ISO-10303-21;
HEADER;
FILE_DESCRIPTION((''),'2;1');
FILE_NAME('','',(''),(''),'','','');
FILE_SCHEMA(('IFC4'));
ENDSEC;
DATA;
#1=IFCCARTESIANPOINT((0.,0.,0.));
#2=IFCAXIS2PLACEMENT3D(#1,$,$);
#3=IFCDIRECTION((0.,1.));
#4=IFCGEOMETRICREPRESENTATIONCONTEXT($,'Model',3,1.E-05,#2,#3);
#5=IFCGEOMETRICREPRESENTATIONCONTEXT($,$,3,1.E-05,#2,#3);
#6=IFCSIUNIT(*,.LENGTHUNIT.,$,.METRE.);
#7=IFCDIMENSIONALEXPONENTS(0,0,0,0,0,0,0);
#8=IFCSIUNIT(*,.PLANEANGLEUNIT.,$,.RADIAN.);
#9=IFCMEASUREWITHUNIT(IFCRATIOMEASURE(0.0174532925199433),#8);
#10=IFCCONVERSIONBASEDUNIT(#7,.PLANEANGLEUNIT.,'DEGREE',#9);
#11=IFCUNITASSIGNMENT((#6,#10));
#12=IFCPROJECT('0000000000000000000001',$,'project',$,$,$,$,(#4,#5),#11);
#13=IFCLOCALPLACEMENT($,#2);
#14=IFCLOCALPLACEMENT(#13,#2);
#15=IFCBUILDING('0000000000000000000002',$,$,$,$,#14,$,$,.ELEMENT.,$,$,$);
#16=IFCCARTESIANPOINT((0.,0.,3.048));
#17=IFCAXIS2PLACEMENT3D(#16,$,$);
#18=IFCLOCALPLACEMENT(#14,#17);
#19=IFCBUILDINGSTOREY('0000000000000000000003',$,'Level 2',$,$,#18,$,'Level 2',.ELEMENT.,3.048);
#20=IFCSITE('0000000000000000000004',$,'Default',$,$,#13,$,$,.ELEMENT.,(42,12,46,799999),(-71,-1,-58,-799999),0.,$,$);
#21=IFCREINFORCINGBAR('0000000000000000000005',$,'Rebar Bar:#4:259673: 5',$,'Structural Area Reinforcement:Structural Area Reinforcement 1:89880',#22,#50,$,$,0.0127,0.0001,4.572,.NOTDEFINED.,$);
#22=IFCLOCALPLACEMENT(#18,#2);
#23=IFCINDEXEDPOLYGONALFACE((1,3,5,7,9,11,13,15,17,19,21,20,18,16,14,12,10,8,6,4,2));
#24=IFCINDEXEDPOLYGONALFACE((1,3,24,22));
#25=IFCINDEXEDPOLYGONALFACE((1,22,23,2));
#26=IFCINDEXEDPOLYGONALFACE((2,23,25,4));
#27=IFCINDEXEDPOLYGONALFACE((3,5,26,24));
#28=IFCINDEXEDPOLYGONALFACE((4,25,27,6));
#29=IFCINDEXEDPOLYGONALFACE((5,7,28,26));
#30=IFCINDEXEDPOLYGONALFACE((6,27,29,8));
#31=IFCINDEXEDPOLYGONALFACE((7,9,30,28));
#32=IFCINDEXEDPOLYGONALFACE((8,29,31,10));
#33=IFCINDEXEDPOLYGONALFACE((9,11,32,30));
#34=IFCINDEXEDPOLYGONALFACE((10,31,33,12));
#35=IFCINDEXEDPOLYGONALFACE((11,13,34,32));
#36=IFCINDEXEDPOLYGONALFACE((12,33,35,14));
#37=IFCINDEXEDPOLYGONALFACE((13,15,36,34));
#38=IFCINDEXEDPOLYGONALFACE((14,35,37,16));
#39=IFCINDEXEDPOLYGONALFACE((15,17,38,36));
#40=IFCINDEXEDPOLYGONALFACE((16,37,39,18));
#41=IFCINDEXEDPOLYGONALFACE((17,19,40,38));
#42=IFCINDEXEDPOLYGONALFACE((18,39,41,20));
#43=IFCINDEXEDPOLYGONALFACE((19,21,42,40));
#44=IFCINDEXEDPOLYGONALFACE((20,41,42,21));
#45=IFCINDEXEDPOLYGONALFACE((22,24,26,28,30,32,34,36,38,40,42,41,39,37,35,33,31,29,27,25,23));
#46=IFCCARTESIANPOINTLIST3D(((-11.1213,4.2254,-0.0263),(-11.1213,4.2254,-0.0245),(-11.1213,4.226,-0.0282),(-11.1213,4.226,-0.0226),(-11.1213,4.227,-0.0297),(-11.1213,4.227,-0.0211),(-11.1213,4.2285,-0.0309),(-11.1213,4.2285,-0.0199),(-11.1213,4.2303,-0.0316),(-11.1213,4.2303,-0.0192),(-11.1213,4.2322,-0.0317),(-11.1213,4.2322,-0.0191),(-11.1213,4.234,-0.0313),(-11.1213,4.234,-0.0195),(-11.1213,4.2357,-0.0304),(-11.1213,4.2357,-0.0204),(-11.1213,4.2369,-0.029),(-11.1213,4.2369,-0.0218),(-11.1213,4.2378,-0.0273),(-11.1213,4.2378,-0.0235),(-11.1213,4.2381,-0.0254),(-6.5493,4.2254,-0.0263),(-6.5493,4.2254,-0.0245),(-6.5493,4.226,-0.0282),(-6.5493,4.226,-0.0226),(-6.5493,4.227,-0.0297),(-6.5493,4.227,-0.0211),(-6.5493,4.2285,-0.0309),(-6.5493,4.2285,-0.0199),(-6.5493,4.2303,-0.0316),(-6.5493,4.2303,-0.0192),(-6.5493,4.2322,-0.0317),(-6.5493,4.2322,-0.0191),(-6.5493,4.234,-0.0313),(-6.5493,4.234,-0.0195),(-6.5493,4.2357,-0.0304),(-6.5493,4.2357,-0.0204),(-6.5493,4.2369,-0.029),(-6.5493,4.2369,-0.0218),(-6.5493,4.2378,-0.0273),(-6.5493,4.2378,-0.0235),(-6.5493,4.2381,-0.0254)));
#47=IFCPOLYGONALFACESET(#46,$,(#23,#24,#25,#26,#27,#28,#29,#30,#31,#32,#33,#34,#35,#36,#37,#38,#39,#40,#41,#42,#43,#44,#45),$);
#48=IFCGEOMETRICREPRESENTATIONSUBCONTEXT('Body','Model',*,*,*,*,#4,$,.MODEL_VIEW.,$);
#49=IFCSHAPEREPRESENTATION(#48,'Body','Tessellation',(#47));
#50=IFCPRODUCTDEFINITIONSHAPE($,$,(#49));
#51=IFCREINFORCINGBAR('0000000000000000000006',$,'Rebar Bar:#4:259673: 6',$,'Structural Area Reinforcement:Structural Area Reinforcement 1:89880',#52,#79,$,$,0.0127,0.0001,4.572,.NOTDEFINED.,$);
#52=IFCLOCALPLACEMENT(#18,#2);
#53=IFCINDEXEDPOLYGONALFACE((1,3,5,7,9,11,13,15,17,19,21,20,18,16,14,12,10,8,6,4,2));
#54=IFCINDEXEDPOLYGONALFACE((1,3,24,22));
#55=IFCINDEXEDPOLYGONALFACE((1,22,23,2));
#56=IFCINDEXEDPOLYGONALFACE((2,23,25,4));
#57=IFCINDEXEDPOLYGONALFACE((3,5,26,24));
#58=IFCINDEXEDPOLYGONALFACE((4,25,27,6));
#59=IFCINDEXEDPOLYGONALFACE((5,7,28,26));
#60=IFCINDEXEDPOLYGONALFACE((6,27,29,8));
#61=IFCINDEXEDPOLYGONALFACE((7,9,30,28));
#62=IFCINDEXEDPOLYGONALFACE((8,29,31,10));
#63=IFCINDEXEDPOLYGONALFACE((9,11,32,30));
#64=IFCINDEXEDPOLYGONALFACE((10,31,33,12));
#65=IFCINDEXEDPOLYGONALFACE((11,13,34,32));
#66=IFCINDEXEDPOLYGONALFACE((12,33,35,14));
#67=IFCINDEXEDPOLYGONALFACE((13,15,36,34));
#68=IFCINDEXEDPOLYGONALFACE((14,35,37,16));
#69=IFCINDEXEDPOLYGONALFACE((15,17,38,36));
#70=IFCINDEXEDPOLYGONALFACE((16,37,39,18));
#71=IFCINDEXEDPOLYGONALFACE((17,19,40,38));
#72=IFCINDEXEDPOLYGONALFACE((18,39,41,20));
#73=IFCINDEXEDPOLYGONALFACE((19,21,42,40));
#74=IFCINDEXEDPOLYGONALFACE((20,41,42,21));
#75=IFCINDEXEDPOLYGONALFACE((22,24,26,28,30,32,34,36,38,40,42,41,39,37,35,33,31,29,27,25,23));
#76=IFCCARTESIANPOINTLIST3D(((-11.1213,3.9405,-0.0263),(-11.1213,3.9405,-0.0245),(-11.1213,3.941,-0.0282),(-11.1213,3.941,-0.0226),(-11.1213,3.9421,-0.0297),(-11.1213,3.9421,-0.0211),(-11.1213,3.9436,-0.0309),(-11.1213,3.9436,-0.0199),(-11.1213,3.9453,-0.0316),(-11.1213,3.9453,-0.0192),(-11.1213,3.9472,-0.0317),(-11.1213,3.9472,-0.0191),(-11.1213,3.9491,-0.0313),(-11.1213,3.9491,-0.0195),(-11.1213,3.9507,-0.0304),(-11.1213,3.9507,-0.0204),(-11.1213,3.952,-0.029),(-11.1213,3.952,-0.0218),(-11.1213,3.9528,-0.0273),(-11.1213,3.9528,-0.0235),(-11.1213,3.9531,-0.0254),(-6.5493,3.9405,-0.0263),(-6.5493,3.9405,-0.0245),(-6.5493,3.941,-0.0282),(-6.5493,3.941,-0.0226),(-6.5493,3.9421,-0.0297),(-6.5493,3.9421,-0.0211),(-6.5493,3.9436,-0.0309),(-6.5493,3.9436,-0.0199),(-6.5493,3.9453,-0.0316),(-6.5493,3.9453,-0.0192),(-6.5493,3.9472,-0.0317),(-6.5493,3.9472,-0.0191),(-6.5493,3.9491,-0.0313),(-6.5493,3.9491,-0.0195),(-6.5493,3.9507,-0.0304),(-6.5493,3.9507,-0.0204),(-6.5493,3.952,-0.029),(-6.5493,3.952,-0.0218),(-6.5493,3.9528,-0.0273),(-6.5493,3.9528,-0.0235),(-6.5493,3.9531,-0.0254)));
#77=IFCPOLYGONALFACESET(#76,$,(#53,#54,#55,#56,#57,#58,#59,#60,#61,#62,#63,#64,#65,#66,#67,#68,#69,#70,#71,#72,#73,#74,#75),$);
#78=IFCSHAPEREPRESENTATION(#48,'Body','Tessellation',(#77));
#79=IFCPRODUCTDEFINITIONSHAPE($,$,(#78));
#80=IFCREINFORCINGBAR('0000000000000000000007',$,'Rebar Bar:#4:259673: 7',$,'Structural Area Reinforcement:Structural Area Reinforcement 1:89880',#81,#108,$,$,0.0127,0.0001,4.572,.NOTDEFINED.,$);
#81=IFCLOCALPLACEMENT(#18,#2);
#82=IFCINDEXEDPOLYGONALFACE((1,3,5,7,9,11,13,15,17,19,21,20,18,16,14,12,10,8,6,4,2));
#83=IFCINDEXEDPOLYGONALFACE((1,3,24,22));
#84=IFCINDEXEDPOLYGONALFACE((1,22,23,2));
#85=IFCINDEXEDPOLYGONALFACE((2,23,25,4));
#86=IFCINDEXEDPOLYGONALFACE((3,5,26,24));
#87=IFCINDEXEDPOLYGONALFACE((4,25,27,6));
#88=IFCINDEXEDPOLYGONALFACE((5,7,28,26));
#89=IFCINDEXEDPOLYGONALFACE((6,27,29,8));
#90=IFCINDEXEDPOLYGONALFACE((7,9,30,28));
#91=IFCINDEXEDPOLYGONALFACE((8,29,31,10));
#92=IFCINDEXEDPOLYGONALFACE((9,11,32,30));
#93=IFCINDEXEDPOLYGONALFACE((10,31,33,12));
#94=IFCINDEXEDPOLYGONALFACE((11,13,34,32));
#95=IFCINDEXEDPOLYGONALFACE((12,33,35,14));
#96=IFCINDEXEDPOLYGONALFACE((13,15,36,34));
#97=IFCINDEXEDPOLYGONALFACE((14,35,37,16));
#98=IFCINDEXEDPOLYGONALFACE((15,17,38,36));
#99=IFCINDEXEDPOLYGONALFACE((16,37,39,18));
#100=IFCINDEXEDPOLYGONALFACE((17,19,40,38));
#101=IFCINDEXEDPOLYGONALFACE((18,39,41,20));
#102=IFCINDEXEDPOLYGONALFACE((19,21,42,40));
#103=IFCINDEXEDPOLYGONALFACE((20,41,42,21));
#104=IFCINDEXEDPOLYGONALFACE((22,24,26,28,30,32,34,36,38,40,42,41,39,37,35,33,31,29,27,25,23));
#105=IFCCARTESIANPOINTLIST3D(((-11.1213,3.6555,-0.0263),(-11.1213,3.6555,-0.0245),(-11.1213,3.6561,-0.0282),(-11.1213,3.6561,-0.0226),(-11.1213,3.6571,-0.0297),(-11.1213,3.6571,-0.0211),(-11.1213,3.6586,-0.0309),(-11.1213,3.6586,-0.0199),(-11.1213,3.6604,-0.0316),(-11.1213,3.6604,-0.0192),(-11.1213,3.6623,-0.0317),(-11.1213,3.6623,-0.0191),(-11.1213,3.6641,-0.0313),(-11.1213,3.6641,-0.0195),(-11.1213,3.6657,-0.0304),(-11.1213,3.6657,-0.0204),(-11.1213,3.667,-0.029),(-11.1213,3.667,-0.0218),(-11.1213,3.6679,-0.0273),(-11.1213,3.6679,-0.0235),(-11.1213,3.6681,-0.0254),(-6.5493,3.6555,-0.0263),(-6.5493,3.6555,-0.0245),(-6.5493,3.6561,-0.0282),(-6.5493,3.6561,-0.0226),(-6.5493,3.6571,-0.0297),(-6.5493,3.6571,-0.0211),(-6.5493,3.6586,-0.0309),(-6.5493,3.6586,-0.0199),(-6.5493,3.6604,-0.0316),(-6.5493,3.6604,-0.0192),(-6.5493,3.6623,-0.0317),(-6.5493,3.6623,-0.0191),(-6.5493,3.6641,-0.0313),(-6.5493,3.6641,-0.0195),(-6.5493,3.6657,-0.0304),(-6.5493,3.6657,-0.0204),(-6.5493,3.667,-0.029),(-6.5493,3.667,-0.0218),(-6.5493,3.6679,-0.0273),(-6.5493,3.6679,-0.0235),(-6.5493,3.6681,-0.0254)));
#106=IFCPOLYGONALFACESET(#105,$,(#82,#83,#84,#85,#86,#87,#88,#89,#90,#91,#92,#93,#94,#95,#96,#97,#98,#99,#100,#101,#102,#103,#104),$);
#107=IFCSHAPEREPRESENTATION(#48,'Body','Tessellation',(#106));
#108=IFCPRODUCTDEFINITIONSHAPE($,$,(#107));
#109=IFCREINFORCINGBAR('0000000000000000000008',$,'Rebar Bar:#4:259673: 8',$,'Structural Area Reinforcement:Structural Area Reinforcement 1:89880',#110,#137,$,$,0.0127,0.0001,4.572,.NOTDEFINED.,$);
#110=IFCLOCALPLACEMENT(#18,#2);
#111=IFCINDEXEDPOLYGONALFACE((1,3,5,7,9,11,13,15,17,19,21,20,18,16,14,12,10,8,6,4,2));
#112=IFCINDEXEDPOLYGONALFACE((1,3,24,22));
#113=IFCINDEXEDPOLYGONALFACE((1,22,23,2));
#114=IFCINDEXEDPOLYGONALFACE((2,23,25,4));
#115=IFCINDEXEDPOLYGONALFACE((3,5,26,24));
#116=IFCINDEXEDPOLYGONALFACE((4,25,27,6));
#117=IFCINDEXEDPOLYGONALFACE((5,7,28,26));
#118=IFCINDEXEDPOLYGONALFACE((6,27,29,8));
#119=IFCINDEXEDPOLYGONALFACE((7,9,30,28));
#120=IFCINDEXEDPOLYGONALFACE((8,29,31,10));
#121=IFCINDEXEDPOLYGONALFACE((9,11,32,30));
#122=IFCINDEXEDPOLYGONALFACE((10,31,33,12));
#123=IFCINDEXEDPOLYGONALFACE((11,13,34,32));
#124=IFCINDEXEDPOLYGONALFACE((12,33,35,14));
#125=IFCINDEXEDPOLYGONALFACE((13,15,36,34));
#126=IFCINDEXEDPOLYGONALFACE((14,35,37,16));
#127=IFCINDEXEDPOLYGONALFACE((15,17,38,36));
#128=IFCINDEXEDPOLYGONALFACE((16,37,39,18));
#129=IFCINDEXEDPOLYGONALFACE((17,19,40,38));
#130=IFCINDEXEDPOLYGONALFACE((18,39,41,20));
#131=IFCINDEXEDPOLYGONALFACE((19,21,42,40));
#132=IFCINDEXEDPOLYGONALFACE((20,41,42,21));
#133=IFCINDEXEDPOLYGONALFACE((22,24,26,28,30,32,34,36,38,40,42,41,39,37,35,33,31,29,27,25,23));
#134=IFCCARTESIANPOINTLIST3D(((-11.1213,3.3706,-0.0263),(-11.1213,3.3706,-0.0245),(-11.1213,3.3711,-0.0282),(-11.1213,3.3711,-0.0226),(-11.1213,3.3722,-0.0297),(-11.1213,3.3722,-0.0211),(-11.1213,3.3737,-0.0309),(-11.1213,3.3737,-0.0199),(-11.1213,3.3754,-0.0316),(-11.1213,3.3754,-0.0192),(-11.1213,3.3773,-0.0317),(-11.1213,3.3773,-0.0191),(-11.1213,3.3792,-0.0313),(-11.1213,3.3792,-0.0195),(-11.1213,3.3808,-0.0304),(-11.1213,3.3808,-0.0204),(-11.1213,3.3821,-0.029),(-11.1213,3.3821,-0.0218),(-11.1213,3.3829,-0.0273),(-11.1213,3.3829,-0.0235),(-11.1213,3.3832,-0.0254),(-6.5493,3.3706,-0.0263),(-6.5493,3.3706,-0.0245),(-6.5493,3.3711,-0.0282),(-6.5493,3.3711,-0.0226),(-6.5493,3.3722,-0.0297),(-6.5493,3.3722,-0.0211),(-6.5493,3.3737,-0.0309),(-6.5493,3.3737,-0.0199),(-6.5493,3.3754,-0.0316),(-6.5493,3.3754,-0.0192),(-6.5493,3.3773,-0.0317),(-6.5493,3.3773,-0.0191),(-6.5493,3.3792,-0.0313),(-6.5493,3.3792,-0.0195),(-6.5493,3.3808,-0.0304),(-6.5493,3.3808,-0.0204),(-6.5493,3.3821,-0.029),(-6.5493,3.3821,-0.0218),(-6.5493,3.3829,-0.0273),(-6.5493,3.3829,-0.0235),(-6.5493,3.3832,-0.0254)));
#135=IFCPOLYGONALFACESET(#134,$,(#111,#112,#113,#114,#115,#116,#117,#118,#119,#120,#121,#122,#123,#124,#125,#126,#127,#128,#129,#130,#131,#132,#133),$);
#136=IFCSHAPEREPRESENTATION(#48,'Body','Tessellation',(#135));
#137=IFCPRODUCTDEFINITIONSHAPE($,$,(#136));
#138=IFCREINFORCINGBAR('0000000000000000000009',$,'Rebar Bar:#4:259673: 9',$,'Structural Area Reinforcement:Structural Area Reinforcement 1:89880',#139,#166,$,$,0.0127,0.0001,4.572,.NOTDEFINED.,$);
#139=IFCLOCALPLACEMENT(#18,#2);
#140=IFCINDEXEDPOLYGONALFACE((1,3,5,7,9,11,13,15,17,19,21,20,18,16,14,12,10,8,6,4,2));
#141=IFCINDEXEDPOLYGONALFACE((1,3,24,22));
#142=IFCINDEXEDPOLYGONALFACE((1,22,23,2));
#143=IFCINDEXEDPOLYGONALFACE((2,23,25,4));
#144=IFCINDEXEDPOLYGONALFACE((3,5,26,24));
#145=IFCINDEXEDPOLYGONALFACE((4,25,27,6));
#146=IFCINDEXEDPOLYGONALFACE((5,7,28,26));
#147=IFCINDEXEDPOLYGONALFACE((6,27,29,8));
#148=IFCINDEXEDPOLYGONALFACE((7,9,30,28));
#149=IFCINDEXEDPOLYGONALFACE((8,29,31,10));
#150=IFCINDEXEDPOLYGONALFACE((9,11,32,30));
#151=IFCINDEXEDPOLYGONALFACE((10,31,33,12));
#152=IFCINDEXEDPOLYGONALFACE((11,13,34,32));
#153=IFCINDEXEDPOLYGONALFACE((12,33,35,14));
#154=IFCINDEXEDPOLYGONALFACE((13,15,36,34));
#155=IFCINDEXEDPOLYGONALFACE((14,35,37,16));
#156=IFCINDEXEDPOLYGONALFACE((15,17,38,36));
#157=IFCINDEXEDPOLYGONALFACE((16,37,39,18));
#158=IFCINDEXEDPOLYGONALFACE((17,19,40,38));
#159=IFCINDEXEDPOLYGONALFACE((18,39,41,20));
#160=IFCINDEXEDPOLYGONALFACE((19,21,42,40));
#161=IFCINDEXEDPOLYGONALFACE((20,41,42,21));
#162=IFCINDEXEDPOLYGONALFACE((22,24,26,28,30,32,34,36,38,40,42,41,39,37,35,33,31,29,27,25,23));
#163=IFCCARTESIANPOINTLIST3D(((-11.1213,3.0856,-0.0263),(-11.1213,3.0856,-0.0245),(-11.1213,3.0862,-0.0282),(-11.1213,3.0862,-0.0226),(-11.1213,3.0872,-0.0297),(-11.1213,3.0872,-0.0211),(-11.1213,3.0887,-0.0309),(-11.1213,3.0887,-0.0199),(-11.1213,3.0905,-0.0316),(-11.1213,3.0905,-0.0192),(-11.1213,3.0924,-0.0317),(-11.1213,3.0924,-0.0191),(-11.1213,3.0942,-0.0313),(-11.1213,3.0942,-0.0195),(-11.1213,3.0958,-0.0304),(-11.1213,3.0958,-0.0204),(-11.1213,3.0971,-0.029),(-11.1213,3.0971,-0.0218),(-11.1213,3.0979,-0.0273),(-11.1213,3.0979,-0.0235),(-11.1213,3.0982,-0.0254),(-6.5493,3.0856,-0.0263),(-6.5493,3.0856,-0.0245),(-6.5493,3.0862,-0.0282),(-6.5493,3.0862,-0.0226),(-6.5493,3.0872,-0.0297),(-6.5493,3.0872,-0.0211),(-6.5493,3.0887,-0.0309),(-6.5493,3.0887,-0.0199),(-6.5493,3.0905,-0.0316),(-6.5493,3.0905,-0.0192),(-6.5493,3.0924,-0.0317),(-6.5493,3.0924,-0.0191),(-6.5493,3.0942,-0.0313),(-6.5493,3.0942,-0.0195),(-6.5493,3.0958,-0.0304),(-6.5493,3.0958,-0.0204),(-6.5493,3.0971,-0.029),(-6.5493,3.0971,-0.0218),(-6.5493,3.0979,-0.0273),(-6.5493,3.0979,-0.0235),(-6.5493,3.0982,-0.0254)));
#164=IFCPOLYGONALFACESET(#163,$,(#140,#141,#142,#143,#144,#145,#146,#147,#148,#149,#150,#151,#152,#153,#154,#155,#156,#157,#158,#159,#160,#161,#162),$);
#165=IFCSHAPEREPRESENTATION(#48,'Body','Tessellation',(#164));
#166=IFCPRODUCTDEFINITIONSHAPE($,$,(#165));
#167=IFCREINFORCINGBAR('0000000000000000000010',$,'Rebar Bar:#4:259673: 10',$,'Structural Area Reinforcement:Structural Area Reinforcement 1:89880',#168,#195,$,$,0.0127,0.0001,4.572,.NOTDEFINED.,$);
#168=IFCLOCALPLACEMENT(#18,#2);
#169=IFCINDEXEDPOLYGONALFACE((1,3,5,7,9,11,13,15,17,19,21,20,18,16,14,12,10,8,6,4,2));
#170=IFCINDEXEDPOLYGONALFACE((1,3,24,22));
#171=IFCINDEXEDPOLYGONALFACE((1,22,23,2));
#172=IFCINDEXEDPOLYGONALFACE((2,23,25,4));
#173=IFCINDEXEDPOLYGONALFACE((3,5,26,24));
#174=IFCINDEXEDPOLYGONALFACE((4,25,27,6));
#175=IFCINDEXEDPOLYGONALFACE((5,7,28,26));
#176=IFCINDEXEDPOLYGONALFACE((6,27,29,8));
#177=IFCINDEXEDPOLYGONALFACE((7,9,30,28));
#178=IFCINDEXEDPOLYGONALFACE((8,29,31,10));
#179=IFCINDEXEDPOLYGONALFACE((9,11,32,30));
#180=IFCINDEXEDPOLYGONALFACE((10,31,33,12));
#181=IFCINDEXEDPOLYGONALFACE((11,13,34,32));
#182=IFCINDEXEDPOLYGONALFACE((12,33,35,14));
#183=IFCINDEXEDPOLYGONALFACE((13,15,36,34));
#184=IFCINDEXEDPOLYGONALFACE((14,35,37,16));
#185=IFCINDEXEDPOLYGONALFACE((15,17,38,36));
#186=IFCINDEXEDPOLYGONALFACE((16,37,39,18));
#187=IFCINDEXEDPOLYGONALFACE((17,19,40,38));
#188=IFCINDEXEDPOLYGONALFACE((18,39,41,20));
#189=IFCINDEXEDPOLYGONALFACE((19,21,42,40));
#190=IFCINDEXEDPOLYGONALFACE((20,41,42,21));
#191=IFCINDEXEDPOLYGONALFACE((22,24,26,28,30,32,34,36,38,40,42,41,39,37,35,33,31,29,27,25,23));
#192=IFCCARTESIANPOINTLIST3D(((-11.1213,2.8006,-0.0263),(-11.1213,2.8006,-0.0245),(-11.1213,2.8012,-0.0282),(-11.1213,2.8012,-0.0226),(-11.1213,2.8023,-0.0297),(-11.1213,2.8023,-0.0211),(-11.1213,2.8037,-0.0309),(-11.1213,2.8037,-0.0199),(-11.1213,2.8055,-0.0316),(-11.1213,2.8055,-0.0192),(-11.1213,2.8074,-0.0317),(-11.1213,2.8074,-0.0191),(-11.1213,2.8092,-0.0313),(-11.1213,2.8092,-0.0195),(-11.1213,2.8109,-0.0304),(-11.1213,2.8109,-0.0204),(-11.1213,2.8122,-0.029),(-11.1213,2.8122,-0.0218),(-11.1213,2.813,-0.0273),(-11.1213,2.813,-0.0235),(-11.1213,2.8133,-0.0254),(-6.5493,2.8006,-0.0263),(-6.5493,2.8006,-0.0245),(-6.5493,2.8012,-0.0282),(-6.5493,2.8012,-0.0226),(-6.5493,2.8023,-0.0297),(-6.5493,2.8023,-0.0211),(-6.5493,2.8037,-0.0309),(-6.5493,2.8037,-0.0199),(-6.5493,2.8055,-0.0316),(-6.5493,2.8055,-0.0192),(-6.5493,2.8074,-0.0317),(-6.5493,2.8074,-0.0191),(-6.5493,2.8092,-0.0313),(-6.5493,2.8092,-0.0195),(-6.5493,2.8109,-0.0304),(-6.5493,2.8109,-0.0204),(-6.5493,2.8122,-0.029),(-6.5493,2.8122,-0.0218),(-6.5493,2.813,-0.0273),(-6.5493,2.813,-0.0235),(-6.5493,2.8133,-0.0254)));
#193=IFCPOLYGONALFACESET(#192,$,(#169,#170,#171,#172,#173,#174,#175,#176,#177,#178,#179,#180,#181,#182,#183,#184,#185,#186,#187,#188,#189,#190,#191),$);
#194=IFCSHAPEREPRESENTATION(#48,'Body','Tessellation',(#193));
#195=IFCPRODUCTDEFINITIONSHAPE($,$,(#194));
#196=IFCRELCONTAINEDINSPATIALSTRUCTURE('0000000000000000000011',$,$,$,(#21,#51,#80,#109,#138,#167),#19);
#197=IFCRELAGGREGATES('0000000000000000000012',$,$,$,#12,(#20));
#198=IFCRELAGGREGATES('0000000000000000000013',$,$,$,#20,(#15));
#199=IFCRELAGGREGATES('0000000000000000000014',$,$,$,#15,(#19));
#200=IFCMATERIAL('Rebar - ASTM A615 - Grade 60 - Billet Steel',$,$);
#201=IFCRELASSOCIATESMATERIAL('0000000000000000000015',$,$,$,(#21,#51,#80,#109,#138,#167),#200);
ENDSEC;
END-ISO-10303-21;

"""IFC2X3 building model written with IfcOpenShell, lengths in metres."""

from ifc_helpers import new_model, entity, si_unit, converted_unit, direction, frame, origin, place, context, subcontext, project, spatial, material, element, save


model = new_model("IFC2X3")

# Units and contexts
model_context = context("Model", 3, precision=1e-05, world=origin(), true_north=direction((0.0, 1.0)))
context_of_model = context(None, 3, precision=1e-05, world=origin(), true_north=direction((0.0, 1.0)))
body_context = subcontext(model_context, "Body", "Model", "MODEL_VIEW")
ifc_project = project(units=[si_unit("LENGTHUNIT", "METRE"), converted_unit("PLANEANGLEUNIT", "DEGREE", entity("IfcRatioMeasure", 0.0174532925199433), si_unit("PLANEANGLEUNIT", "RADIAN"), dimensions=[0, 0, 0, 0, 0, 0, 0])], contexts=[model_context, context_of_model])

# Site, building, storey
site_placement = place(None, origin())
site = spatial("IfcSite", under=ifc_project, at=site_placement, Name="Default", CompositionType="ELEMENT", RefLatitude=(42, 12, 46, 799999), RefLongitude=(-71, -1, -58, -799999), RefElevation=0.0)
building_placement = place(site_placement, origin())
building = spatial("IfcBuilding", under=site, at=building_placement, CompositionType="ELEMENT")
storey_placement = place(building_placement, frame((0.0, 0.0, 3.048)))
storey = spatial("IfcBuildingStorey", under=building, at=storey_placement, Name="Level 2", LongName="Level 2", CompositionType="ELEMENT", Elevation=3.048)

# Reinforcing bars
ifc_material_1 = material(Name="Rebar - ASTM A615 - Grade 60 - Billet Steel")
reinforcing_bar_1_placement = place(storey_placement, origin())
element("IfcReinforcingBar", 1, at=reinforcing_bar_1_placement, inside=storey, material=ifc_material_1, Name="Rebar Bar:#4:259673: 5", ObjectType="Structural Area Reinforcement:Structural Area Reinforcement 1:89880", BarLength=4.572, BarRole="NOTDEFINED", CrossSectionArea=0.0001, NominalDiameter=0.0127, context=body_context, shape_type="AdvancedSweptSolid", body=[
    entity("IfcSweptDiskSolid", entity("IfcCompositeCurve", [entity("IfcCompositeCurveSegment", "CONTINUOUS", True, entity("IfcPolyline", [entity("IfcCartesianPoint", [-11.1213, 4.2317, -0.0254]), entity("IfcCartesianPoint", [-6.5493, 4.2317, -0.0254])]))], False), 0.0063, None, 0.0, 1.0),
])
reinforcing_bar_2_placement = place(storey_placement, origin())
element("IfcReinforcingBar", 2, at=reinforcing_bar_2_placement, inside=storey, material=ifc_material_1, Name="Rebar Bar:#4:259673: 6", ObjectType="Structural Area Reinforcement:Structural Area Reinforcement 1:89880", BarLength=4.572, BarRole="NOTDEFINED", CrossSectionArea=0.0001, NominalDiameter=0.0127, context=body_context, shape_type="AdvancedSweptSolid", body=[
    entity("IfcSweptDiskSolid", entity("IfcCompositeCurve", [entity("IfcCompositeCurveSegment", "CONTINUOUS", True, entity("IfcPolyline", [entity("IfcCartesianPoint", [-11.1213, 3.9467, -0.0254]), entity("IfcCartesianPoint", [-6.5493, 3.9467, -0.0254])]))], False), 0.0063, None, 0.0, 1.0),
])
reinforcing_bar_3_placement = place(storey_placement, origin())
element("IfcReinforcingBar", 3, at=reinforcing_bar_3_placement, inside=storey, material=ifc_material_1, Name="Rebar Bar:#4:259673: 7", ObjectType="Structural Area Reinforcement:Structural Area Reinforcement 1:89880", BarLength=4.572, BarRole="NOTDEFINED", CrossSectionArea=0.0001, NominalDiameter=0.0127, context=body_context, shape_type="AdvancedSweptSolid", body=[
    entity("IfcSweptDiskSolid", entity("IfcCompositeCurve", [entity("IfcCompositeCurveSegment", "CONTINUOUS", True, entity("IfcPolyline", [entity("IfcCartesianPoint", [-11.1213, 3.6618, -0.0254]), entity("IfcCartesianPoint", [-6.5493, 3.6618, -0.0254])]))], False), 0.0063, None, 0.0, 1.0),
])
reinforcing_bar_4_placement = place(storey_placement, origin())
element("IfcReinforcingBar", 4, at=reinforcing_bar_4_placement, inside=storey, material=ifc_material_1, Name="Rebar Bar:#4:259673: 8", ObjectType="Structural Area Reinforcement:Structural Area Reinforcement 1:89880", BarLength=4.572, BarRole="NOTDEFINED", CrossSectionArea=0.0001, NominalDiameter=0.0127, context=body_context, shape_type="AdvancedSweptSolid", body=[
    entity("IfcSweptDiskSolid", entity("IfcCompositeCurve", [entity("IfcCompositeCurveSegment", "CONTINUOUS", True, entity("IfcPolyline", [entity("IfcCartesianPoint", [-11.1213, 3.3768, -0.0254]), entity("IfcCartesianPoint", [-6.5493, 3.3768, -0.0254])]))], False), 0.0063, None, 0.0, 1.0),
])
reinforcing_bar_5_placement = place(storey_placement, origin())
element("IfcReinforcingBar", 5, at=reinforcing_bar_5_placement, inside=storey, material=ifc_material_1, Name="Rebar Bar:#4:259673: 9", ObjectType="Structural Area Reinforcement:Structural Area Reinforcement 1:89880", BarLength=4.572, BarRole="NOTDEFINED", CrossSectionArea=0.0001, NominalDiameter=0.0127, context=body_context, shape_type="AdvancedSweptSolid", body=[
    entity("IfcSweptDiskSolid", entity("IfcCompositeCurve", [entity("IfcCompositeCurveSegment", "CONTINUOUS", True, entity("IfcPolyline", [entity("IfcCartesianPoint", [-11.1213, 3.0919, -0.0254]), entity("IfcCartesianPoint", [-6.5493, 3.0919, -0.0254])]))], False), 0.0063, None, 0.0, 1.0),
])
reinforcing_bar_6_placement = place(storey_placement, origin())
element("IfcReinforcingBar", 6, at=reinforcing_bar_6_placement, inside=storey, material=ifc_material_1, Name="Rebar Bar:#4:259673: 10", ObjectType="Structural Area Reinforcement:Structural Area Reinforcement 1:89880", BarLength=4.572, BarRole="NOTDEFINED", CrossSectionArea=0.0001, NominalDiameter=0.0127, context=body_context, shape_type="AdvancedSweptSolid", body=[
    entity("IfcSweptDiskSolid", entity("IfcCompositeCurve", [entity("IfcCompositeCurveSegment", "CONTINUOUS", True, entity("IfcPolyline", [entity("IfcCartesianPoint", [-11.1213, 2.8069, -0.0254]), entity("IfcCartesianPoint", [-6.5493, 2.8069, -0.0254])]))], False), 0.0063, None, 0.0, 1.0),
])

save(model, "model.ifc")
